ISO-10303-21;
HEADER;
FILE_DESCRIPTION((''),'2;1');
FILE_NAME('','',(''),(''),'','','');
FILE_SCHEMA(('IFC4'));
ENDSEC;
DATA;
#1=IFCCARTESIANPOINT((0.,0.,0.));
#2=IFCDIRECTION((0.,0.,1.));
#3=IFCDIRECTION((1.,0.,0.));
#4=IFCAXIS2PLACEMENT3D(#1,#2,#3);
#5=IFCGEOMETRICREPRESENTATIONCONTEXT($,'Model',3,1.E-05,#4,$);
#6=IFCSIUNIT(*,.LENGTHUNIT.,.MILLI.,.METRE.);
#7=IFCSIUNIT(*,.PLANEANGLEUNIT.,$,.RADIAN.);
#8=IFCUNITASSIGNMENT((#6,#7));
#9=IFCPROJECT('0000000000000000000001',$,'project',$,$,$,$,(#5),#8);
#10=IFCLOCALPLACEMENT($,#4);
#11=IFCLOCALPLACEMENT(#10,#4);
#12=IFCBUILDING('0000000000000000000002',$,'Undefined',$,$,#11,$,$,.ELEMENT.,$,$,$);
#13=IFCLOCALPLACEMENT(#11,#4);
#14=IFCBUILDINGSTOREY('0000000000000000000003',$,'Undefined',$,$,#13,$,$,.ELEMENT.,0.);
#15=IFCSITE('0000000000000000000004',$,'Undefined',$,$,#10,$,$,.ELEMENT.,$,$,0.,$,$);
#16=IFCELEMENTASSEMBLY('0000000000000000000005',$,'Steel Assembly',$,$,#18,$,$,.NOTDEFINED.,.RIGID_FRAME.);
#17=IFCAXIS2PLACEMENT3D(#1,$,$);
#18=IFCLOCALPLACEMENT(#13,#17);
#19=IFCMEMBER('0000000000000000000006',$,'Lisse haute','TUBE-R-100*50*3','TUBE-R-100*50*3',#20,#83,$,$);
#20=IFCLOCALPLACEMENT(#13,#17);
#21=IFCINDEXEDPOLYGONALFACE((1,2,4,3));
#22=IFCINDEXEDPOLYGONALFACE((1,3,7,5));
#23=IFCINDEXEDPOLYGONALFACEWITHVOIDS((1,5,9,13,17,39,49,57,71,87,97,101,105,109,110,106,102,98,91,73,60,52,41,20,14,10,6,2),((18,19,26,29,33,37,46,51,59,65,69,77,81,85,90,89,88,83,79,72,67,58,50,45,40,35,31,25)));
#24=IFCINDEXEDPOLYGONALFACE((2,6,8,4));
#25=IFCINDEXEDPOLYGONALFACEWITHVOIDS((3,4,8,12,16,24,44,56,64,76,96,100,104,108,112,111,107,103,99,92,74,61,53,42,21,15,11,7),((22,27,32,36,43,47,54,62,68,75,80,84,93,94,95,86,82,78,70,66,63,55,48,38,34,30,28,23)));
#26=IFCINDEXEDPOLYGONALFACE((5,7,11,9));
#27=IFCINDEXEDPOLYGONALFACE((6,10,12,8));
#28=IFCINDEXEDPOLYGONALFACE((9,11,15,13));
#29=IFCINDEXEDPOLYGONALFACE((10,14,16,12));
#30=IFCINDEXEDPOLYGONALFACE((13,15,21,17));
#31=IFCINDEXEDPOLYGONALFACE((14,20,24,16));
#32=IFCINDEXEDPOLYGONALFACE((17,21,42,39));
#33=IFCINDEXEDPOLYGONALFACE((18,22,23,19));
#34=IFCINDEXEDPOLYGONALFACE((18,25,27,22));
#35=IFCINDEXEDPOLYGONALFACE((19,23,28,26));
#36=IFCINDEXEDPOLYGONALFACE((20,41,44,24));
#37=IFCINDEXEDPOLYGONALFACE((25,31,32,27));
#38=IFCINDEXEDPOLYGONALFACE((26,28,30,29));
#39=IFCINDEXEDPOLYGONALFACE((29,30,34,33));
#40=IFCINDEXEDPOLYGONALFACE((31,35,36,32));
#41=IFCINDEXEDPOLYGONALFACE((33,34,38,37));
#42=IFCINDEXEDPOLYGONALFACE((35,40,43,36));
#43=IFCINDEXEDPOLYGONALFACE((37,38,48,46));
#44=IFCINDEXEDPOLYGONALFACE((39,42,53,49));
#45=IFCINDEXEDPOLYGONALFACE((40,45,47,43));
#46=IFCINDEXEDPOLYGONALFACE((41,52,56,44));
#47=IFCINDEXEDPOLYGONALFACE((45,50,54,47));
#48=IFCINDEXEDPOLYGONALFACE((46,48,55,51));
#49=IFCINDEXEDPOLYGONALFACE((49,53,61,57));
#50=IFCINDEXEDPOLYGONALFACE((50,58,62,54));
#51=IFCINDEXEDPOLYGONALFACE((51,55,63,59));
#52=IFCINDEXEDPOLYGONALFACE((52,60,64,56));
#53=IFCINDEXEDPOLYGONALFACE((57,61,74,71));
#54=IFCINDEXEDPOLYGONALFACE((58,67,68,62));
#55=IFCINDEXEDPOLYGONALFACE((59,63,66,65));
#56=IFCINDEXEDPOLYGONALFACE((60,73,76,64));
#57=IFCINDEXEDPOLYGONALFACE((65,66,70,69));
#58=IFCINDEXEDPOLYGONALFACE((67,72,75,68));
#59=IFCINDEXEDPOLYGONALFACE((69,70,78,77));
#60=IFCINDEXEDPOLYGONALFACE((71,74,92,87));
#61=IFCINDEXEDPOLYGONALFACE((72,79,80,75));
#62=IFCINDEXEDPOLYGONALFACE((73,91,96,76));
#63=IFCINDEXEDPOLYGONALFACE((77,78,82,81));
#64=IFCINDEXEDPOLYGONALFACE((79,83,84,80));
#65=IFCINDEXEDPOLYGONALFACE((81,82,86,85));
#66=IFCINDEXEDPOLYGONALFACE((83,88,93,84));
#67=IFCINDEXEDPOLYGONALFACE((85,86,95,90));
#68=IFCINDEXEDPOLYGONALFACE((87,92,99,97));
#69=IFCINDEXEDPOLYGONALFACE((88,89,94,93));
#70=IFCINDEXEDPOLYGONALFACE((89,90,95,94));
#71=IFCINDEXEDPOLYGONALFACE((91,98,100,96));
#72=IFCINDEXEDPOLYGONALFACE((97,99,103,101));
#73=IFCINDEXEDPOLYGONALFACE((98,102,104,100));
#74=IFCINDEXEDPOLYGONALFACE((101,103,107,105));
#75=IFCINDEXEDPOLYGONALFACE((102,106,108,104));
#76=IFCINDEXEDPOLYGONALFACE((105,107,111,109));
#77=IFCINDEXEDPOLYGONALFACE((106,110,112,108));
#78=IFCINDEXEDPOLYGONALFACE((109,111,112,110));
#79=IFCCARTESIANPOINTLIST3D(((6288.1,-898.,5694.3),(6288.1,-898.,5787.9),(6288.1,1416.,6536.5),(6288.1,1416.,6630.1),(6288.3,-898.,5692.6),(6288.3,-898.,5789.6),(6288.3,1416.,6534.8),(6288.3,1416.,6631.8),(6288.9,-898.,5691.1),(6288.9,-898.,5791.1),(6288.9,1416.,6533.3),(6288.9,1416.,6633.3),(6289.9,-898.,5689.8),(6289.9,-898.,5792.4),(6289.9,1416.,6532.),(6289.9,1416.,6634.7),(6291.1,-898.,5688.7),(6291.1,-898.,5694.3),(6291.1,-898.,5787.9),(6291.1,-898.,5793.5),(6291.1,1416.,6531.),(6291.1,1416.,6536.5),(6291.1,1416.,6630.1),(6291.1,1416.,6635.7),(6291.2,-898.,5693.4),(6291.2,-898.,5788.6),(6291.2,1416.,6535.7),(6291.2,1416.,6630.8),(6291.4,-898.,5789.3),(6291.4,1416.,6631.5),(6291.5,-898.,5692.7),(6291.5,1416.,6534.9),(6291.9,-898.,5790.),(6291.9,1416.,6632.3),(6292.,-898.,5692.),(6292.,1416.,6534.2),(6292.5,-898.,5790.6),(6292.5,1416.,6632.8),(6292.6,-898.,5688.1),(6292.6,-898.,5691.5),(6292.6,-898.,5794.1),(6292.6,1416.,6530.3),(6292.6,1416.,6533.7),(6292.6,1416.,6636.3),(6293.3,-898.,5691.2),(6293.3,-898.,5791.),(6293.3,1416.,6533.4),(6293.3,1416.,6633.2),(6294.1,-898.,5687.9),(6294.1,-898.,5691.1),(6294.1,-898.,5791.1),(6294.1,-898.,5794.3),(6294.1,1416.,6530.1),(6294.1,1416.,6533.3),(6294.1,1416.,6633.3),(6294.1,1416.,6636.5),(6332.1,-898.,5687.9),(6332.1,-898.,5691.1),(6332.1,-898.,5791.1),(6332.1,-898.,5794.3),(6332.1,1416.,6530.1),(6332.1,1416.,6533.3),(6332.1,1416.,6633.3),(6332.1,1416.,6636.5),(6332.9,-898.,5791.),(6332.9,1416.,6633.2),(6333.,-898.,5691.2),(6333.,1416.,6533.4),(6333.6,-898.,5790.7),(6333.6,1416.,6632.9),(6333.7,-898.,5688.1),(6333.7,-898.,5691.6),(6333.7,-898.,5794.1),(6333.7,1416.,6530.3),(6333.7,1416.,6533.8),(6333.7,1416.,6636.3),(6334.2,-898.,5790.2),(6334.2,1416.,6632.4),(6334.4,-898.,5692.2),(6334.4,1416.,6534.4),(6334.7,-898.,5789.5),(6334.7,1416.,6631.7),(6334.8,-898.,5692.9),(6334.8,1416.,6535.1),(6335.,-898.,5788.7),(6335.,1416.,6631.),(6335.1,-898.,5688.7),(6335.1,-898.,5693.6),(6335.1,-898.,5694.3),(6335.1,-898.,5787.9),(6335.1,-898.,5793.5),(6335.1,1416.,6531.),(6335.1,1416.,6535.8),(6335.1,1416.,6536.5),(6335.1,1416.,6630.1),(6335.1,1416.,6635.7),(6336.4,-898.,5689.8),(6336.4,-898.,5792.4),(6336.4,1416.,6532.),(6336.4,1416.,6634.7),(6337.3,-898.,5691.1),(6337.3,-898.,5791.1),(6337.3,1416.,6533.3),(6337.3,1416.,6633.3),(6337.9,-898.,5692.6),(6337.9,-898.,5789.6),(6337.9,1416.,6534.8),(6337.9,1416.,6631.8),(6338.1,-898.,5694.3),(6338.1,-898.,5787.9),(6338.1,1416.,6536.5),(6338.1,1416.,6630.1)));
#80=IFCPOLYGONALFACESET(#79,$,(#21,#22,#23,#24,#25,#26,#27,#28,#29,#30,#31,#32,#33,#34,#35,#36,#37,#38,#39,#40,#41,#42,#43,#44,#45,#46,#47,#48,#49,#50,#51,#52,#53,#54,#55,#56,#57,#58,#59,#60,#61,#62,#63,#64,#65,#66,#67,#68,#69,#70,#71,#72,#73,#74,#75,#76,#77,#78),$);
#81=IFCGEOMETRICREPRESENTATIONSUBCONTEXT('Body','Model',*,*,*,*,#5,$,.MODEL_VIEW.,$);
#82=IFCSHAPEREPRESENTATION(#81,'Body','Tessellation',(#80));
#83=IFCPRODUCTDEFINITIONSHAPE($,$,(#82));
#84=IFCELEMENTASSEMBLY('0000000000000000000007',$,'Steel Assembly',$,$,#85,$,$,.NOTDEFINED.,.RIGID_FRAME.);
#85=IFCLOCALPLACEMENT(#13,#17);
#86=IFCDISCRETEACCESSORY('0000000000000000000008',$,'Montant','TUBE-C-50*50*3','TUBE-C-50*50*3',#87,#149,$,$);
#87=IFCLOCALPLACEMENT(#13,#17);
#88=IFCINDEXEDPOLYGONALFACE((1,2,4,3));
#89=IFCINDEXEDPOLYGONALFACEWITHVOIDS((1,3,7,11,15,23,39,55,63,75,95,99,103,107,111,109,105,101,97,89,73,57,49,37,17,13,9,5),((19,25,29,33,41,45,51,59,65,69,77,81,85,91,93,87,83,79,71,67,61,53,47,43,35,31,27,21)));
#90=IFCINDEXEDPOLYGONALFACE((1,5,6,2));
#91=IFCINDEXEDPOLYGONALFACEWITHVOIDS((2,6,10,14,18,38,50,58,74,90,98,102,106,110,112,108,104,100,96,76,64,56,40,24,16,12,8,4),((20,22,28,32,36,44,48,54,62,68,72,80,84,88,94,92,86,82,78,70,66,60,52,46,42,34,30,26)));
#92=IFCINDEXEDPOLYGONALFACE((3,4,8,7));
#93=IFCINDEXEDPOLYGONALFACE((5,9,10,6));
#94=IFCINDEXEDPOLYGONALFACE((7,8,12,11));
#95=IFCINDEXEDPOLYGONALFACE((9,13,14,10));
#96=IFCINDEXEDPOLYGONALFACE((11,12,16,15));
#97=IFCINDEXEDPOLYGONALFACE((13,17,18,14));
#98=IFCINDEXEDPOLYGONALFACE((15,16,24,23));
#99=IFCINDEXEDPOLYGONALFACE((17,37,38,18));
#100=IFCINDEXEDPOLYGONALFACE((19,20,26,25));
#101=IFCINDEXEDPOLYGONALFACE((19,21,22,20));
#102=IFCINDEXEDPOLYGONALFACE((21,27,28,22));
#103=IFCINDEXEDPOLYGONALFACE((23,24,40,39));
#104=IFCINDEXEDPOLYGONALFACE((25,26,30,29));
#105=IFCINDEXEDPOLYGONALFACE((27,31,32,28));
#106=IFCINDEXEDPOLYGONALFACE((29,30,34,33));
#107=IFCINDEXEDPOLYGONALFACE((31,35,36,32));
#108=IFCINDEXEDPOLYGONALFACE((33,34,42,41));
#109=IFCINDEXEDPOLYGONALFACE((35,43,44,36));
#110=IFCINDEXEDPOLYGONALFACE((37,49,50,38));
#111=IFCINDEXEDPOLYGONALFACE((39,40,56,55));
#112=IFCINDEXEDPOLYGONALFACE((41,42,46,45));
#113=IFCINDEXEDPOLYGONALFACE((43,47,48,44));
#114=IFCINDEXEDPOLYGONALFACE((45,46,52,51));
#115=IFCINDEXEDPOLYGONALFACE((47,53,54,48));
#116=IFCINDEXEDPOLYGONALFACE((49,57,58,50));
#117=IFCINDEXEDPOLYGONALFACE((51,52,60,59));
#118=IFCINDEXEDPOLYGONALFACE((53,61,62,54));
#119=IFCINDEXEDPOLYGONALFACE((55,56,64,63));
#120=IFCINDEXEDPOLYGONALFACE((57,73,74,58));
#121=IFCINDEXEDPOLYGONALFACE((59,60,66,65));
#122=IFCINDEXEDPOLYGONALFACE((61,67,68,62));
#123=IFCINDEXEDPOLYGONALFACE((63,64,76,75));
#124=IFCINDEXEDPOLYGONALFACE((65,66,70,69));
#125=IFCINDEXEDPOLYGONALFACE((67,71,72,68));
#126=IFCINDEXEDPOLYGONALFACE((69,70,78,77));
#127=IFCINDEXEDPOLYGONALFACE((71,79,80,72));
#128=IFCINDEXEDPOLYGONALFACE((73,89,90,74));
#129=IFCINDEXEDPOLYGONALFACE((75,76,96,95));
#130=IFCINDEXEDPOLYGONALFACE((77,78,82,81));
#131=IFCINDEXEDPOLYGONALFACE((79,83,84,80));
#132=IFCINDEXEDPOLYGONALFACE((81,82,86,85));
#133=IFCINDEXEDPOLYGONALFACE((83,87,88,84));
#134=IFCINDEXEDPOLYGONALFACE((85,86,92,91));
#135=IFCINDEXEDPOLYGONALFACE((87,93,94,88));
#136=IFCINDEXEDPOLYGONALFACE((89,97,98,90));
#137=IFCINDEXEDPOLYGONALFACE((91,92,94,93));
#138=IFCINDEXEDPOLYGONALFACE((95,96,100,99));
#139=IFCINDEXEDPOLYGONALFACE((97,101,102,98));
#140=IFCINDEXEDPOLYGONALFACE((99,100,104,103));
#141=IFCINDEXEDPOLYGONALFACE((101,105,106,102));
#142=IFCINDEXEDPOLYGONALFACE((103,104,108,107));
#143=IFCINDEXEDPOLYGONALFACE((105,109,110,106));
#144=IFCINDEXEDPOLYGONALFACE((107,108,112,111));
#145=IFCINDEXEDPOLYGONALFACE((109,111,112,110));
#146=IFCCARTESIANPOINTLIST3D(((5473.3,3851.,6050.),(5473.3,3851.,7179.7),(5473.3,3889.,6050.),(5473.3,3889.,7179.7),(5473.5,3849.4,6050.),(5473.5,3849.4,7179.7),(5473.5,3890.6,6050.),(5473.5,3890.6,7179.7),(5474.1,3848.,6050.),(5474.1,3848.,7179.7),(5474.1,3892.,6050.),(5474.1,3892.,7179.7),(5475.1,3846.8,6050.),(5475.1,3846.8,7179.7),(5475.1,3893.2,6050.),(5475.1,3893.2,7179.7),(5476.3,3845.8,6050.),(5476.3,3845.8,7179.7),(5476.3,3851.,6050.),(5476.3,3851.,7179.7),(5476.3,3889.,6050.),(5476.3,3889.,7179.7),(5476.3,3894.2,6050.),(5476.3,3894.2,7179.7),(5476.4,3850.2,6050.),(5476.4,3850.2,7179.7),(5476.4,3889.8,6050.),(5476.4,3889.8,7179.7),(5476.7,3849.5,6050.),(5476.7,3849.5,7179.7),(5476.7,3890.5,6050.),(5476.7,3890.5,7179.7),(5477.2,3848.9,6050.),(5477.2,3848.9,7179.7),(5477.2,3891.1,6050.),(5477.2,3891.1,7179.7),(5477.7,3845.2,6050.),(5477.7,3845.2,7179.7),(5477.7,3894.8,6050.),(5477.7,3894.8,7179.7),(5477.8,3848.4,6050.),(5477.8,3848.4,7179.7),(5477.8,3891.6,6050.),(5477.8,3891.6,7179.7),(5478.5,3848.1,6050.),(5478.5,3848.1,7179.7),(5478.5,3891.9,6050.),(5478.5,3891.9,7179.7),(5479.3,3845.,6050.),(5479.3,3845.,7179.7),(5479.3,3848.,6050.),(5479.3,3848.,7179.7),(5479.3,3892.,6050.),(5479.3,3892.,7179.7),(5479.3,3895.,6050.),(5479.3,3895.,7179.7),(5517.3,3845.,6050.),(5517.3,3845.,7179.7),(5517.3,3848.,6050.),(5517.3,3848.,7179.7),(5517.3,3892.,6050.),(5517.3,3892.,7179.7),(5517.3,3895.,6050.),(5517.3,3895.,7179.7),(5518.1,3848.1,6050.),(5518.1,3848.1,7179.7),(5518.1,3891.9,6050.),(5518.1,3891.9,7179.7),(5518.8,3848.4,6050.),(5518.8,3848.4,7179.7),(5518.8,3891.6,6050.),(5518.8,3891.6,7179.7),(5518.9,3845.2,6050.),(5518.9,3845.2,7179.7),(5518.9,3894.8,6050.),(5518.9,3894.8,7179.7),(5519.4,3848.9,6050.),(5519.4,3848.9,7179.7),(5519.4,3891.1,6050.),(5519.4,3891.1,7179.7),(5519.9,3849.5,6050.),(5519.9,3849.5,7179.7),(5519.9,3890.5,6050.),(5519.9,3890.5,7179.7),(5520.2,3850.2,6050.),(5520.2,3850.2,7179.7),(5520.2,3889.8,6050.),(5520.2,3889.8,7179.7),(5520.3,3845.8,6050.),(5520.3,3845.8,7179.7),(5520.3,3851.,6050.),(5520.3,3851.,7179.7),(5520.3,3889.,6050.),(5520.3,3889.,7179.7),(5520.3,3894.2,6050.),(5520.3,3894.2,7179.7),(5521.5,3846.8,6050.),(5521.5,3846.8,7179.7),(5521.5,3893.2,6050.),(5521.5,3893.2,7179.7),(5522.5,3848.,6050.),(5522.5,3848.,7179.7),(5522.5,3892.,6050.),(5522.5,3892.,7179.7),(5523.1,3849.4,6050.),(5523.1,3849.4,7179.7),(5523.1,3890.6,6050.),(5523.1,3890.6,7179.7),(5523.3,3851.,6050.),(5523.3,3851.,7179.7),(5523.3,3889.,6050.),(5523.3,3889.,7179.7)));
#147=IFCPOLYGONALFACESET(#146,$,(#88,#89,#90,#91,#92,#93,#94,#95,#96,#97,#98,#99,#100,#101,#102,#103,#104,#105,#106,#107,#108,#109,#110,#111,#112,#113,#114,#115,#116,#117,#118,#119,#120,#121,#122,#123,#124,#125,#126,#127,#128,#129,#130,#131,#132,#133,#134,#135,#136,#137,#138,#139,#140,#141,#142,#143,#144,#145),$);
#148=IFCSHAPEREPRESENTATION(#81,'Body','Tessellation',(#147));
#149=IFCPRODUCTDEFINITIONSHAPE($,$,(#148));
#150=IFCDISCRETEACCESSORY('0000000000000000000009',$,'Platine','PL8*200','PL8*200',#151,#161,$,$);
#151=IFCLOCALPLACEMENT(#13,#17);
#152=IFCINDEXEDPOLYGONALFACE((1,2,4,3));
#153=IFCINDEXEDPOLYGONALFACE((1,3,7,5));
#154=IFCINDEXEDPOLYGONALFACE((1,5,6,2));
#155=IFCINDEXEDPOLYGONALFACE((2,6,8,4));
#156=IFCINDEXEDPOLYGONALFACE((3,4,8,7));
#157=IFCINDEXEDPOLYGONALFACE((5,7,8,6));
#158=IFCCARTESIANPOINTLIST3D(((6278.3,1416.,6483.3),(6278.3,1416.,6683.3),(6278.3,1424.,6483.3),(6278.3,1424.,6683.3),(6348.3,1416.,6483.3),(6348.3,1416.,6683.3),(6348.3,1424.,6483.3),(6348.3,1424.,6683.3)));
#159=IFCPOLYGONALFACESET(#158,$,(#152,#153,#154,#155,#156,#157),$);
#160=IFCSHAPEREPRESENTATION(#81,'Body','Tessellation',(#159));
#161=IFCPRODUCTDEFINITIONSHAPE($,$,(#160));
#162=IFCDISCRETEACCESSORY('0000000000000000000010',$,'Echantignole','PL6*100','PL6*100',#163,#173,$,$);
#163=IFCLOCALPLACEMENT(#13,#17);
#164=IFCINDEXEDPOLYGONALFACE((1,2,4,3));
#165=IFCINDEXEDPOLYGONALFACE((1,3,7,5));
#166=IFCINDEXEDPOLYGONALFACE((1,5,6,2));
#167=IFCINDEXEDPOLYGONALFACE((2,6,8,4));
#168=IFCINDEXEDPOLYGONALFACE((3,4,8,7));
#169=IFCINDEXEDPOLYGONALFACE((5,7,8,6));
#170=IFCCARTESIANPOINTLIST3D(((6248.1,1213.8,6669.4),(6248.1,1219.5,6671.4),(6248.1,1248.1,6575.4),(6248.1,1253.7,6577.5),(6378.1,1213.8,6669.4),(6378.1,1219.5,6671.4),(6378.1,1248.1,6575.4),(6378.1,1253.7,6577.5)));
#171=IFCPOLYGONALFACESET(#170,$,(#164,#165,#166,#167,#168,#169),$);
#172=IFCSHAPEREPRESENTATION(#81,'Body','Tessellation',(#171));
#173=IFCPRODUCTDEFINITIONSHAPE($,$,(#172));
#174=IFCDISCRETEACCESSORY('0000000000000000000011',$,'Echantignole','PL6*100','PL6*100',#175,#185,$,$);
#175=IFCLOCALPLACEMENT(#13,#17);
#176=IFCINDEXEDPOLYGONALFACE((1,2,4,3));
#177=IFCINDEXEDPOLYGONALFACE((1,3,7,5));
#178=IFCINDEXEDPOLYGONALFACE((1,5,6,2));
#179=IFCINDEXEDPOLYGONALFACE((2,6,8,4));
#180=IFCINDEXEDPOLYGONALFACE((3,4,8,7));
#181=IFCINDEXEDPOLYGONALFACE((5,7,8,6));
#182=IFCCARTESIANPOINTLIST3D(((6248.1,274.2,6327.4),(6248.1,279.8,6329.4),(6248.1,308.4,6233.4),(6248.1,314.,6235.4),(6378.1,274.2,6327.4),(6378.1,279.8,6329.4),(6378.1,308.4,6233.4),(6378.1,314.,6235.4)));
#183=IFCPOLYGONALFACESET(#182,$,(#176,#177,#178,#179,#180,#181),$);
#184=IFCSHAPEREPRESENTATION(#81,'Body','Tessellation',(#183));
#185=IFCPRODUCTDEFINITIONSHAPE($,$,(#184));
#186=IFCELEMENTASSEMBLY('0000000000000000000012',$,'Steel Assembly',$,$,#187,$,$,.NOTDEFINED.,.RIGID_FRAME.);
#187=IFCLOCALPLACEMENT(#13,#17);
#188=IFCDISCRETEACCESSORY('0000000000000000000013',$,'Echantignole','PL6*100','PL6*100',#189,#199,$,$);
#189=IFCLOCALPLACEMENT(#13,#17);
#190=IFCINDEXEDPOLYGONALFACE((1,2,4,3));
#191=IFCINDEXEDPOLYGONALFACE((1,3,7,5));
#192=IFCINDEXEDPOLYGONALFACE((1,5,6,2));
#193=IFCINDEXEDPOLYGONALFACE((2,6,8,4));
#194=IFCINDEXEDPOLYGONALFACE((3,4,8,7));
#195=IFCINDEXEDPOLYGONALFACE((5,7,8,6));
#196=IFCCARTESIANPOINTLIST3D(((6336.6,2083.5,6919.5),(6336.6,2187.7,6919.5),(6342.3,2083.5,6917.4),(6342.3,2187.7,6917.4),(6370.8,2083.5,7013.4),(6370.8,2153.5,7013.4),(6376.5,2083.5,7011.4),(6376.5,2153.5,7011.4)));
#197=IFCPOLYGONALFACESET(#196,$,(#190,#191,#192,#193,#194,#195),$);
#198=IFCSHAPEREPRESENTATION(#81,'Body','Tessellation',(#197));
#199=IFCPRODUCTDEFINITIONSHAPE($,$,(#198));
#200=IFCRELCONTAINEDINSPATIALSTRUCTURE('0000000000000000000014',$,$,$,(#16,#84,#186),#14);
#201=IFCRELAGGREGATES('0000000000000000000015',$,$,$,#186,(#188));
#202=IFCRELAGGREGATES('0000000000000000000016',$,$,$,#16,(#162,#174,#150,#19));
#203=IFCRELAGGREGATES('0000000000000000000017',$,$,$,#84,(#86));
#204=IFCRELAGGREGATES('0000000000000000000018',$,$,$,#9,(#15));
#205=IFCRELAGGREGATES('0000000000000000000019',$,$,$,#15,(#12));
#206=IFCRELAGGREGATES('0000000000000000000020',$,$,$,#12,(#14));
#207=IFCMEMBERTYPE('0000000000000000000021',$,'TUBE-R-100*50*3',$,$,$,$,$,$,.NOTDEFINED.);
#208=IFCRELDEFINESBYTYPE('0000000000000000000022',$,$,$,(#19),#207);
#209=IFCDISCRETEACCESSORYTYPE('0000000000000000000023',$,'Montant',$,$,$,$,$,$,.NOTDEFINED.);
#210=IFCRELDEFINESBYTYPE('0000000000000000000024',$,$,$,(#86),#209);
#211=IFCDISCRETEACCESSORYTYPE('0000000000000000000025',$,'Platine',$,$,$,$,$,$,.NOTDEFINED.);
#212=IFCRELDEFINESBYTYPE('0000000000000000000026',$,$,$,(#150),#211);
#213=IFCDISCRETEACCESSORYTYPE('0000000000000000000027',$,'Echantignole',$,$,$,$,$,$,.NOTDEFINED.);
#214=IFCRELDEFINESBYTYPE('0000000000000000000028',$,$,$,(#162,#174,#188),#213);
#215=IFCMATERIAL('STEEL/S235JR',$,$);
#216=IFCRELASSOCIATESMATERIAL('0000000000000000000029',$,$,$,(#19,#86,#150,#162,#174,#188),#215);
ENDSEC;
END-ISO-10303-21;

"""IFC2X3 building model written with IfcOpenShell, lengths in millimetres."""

from ifc_helpers import new_model, si_unit, frame, origin_with_axes, origin_2d_with_axis, place, context, subcontext, project, spatial, polyline, hollow_rectangle, outline, extrude, clip, halfspace, material, type_object, element, aggregate, save


model = new_model("IFC2X3")

# Units and contexts
model_context = context("Model", 3, precision=1e-05, world=origin_with_axes())
body_context = subcontext(model_context, "Body", "Model", "MODEL_VIEW")
ifc_project = project(units=[si_unit("LENGTHUNIT", "METRE", prefix="MILLI"), si_unit("PLANEANGLEUNIT", "RADIAN")], contexts=[model_context])

# Site, building, storey
site_placement = place(None, origin_with_axes())
site = spatial("IfcSite", under=ifc_project, at=site_placement, Name="Undefined", CompositionType="ELEMENT", RefElevation=0.0)
building_placement = place(site_placement, origin_with_axes())
building = spatial("IfcBuilding", under=site, at=building_placement, Name="Undefined", CompositionType="ELEMENT")
storey_placement = place(building_placement, origin_with_axes())
storey = spatial("IfcBuildingStorey", under=building, at=storey_placement, Name="Undefined", CompositionType="ELEMENT", Elevation=0.0)

# Element assembly, member
assembly_1_placement = place(storey_placement, origin_with_axes())
assembly_1 = element("IfcElementAssembly", 1, at=assembly_1_placement, inside=storey, Name="Steel Assembly", AssemblyPlace="NOTDEFINED", PredefinedType="RIGID_FRAME")
ifc_material_1 = material(Name="STEEL/S235JR")
member_type = type_object("IfcMemberType", Name="TUBE-R-100*50*3", PredefinedType="NOTDEFINED")
member_placement = place(assembly_1_placement, frame((6313.1, 1332.1, 6552.8), z_axis=(0.0, -0.34202, 0.939693), x_axis=(0.0, -0.939693, -0.34202)))
member = element("IfcMember", 2, at=member_placement, type_object=member_type, material=ifc_material_1, Name="Lisse haute", Description="TUBE-R-100*50*3", ObjectType="TUBE-R-100*50*3", context=body_context, shape_type="Clipping", body=[
    clip(clip(extrude(hollow_rectangle(XDim=50.0, YDim=100.0, WallThickness=3.0, InnerFilletRadius=3.0, OuterFilletRadius=6.0, at=origin_2d_with_axis()), frame((2410.0, 0.0, 0.0), z_axis=(-1.0, 0.0, 0.0), x_axis=(0.0, -1.0, 0.0)), (0.0, 0.0, 1.0), 2536.0), halfspace(frame((2387.4, 0.0, -38.8), z_axis=(0.939693, 0.0, 0.34202), x_axis=(0.0, -1.0, 0.0)), False)), halfspace(frame((-89.3, 25.2, 0.0), z_axis=(0.939693, 0.0, 0.34202), x_axis=(0.34202, 0.0, -0.939693)), True)),
])

# Element assembly, discrete accessory
assembly_2_placement = place(storey_placement, origin_with_axes())
assembly_2 = element("IfcElementAssembly", 3, at=assembly_2_placement, inside=storey, Name="Steel Assembly", AssemblyPlace="NOTDEFINED", PredefinedType="RIGID_FRAME")
discrete_accessory_type_1 = type_object("IfcDiscreteAccessoryType", Name="Montant")
discrete_accessory_1_placement = place(assembly_2_placement, frame((5498.3, 3870.0, 6050.0), z_axis=(0.0, 0.0, 1.0), x_axis=(1.0, 0.0, 0.0)))
discrete_accessory_1 = element("IfcDiscreteAccessory", 4, at=discrete_accessory_1_placement, type_object=discrete_accessory_type_1, material=ifc_material_1, Name="Montant", Description="TUBE-C-50*50*3", ObjectType="TUBE-C-50*50*3", context=body_context, shape_type="SweptSolid", body=[
    extrude(hollow_rectangle(XDim=50.0, YDim=50.0, WallThickness=3.0, InnerFilletRadius=3.0, OuterFilletRadius=6.0, at=origin_2d_with_axis()), frame((0.0, 0.0, 1129.7), z_axis=(0.0, 0.0, -1.0), x_axis=(0.0, -1.0, 0.0)), (0.0, 0.0, 1.0), 1129.7),
])

# Discrete accessories
discrete_accessory_type_2 = type_object("IfcDiscreteAccessoryType", Name="Platine")
discrete_accessory_2_placement = place(assembly_1_placement, frame((6348.3, 1420.0, 6583.3), z_axis=(0.0, -1.0, 0.0), x_axis=(-1.0, 0.0, 0.0)))
discrete_accessory_2 = element("IfcDiscreteAccessory", 5, at=discrete_accessory_2_placement, type_object=discrete_accessory_type_2, material=ifc_material_1, Name="Platine", Description="PL8*200", ObjectType="PL8*200", context=body_context, shape_type="SweptSolid", body=[
    extrude(outline(polyline([(70.0, -100.0), (0.0, -100.0), (0.0, 100.0), (70.0, 100.0), (70.0, -100.0)])), frame((0.0, 0.0, -4.0), z_axis=(0.0, 0.0, 1.0), x_axis=(1.0, 0.0, 0.0)), (0.0, 0.0, 1.0), 8.0),
])
discrete_accessory_type_3 = type_object("IfcDiscreteAccessoryType", Name="Echantignole")
discrete_accessory_3_placement = place(assembly_1_placement, frame((6248.1, 1233.8, 6623.4), z_axis=(0.0, -0.939693, -0.34202), x_axis=(1.0, 0.0, 0.0)))
discrete_accessory_3 = element("IfcDiscreteAccessory", 6, at=discrete_accessory_3_placement, type_object=discrete_accessory_type_3, material=ifc_material_1, Name="Echantignole", Description="PL6*100", ObjectType="PL6*100", context=body_context, shape_type="SweptSolid", body=[
    extrude(outline(polyline([(130.0, 50.0), (130.0, -50.0), (0.0, -50.0), (0.0, 50.0), (130.0, 50.0)])), frame((0.0, 0.0, -3.0), z_axis=(0.0, 0.0, 1.0), x_axis=(1.0, 0.0, 0.0)), (0.0, 0.0, 1.0), 6.0),
])
discrete_accessory_4_placement = place(assembly_1_placement, frame((6248.1, 294.1, 6281.4), z_axis=(0.0, -0.939693, -0.34202), x_axis=(1.0, 0.0, 0.0)))
discrete_accessory_4 = element("IfcDiscreteAccessory", 7, at=discrete_accessory_4_placement, type_object=discrete_accessory_type_3, material=ifc_material_1, Name="Echantignole", Description="PL6*100", ObjectType="PL6*100", context=body_context, shape_type="SweptSolid", body=[
    extrude(outline(polyline([(130.0, 50.0), (130.0, -50.0), (0.0, -50.0), (0.0, 50.0), (130.0, 50.0)])), frame((0.0, 0.0, -3.0), z_axis=(0.0, 0.0, 1.0), x_axis=(1.0, 0.0, 0.0)), (0.0, 0.0, 1.0), 6.0),
])

# Element assembly, discrete accessory
assembly_3_placement = place(storey_placement, origin_with_axes())
assembly_3 = element("IfcElementAssembly", 8, at=assembly_3_placement, inside=storey, Name="Steel Assembly", AssemblyPlace="NOTDEFINED", PredefinedType="RIGID_FRAME")
discrete_accessory_5_placement = place(assembly_3_placement, frame((6373.6, 2153.5, 7012.4), z_axis=(0.939693, 0.0, -0.34202), x_axis=(0.0, -1.0, 0.0)))
discrete_accessory_5 = element("IfcDiscreteAccessory", 9, at=discrete_accessory_5_placement, type_object=discrete_accessory_type_3, material=ifc_material_1, Name="Echantignole", Description="PL6*100", ObjectType="PL6*100", context=body_context, shape_type="SweptSolid", body=[
    extrude(outline(polyline([(0.0, 0.0), (70.0, 0.0), (70.0, 100.0), (-34.2, 100.0), (0.0, 0.0)])), frame((0.0, 0.0, -3.0), z_axis=(0.0, 0.0, 1.0), x_axis=(1.0, 0.0, 0.0)), (0.0, 0.0, 1.0), 6.0),
])

aggregate(assembly_3, [discrete_accessory_5])

aggregate(assembly_1, [discrete_accessory_3, discrete_accessory_4, discrete_accessory_2, member])

aggregate(assembly_2, [discrete_accessory_1])

save(model, "model.ifc")
